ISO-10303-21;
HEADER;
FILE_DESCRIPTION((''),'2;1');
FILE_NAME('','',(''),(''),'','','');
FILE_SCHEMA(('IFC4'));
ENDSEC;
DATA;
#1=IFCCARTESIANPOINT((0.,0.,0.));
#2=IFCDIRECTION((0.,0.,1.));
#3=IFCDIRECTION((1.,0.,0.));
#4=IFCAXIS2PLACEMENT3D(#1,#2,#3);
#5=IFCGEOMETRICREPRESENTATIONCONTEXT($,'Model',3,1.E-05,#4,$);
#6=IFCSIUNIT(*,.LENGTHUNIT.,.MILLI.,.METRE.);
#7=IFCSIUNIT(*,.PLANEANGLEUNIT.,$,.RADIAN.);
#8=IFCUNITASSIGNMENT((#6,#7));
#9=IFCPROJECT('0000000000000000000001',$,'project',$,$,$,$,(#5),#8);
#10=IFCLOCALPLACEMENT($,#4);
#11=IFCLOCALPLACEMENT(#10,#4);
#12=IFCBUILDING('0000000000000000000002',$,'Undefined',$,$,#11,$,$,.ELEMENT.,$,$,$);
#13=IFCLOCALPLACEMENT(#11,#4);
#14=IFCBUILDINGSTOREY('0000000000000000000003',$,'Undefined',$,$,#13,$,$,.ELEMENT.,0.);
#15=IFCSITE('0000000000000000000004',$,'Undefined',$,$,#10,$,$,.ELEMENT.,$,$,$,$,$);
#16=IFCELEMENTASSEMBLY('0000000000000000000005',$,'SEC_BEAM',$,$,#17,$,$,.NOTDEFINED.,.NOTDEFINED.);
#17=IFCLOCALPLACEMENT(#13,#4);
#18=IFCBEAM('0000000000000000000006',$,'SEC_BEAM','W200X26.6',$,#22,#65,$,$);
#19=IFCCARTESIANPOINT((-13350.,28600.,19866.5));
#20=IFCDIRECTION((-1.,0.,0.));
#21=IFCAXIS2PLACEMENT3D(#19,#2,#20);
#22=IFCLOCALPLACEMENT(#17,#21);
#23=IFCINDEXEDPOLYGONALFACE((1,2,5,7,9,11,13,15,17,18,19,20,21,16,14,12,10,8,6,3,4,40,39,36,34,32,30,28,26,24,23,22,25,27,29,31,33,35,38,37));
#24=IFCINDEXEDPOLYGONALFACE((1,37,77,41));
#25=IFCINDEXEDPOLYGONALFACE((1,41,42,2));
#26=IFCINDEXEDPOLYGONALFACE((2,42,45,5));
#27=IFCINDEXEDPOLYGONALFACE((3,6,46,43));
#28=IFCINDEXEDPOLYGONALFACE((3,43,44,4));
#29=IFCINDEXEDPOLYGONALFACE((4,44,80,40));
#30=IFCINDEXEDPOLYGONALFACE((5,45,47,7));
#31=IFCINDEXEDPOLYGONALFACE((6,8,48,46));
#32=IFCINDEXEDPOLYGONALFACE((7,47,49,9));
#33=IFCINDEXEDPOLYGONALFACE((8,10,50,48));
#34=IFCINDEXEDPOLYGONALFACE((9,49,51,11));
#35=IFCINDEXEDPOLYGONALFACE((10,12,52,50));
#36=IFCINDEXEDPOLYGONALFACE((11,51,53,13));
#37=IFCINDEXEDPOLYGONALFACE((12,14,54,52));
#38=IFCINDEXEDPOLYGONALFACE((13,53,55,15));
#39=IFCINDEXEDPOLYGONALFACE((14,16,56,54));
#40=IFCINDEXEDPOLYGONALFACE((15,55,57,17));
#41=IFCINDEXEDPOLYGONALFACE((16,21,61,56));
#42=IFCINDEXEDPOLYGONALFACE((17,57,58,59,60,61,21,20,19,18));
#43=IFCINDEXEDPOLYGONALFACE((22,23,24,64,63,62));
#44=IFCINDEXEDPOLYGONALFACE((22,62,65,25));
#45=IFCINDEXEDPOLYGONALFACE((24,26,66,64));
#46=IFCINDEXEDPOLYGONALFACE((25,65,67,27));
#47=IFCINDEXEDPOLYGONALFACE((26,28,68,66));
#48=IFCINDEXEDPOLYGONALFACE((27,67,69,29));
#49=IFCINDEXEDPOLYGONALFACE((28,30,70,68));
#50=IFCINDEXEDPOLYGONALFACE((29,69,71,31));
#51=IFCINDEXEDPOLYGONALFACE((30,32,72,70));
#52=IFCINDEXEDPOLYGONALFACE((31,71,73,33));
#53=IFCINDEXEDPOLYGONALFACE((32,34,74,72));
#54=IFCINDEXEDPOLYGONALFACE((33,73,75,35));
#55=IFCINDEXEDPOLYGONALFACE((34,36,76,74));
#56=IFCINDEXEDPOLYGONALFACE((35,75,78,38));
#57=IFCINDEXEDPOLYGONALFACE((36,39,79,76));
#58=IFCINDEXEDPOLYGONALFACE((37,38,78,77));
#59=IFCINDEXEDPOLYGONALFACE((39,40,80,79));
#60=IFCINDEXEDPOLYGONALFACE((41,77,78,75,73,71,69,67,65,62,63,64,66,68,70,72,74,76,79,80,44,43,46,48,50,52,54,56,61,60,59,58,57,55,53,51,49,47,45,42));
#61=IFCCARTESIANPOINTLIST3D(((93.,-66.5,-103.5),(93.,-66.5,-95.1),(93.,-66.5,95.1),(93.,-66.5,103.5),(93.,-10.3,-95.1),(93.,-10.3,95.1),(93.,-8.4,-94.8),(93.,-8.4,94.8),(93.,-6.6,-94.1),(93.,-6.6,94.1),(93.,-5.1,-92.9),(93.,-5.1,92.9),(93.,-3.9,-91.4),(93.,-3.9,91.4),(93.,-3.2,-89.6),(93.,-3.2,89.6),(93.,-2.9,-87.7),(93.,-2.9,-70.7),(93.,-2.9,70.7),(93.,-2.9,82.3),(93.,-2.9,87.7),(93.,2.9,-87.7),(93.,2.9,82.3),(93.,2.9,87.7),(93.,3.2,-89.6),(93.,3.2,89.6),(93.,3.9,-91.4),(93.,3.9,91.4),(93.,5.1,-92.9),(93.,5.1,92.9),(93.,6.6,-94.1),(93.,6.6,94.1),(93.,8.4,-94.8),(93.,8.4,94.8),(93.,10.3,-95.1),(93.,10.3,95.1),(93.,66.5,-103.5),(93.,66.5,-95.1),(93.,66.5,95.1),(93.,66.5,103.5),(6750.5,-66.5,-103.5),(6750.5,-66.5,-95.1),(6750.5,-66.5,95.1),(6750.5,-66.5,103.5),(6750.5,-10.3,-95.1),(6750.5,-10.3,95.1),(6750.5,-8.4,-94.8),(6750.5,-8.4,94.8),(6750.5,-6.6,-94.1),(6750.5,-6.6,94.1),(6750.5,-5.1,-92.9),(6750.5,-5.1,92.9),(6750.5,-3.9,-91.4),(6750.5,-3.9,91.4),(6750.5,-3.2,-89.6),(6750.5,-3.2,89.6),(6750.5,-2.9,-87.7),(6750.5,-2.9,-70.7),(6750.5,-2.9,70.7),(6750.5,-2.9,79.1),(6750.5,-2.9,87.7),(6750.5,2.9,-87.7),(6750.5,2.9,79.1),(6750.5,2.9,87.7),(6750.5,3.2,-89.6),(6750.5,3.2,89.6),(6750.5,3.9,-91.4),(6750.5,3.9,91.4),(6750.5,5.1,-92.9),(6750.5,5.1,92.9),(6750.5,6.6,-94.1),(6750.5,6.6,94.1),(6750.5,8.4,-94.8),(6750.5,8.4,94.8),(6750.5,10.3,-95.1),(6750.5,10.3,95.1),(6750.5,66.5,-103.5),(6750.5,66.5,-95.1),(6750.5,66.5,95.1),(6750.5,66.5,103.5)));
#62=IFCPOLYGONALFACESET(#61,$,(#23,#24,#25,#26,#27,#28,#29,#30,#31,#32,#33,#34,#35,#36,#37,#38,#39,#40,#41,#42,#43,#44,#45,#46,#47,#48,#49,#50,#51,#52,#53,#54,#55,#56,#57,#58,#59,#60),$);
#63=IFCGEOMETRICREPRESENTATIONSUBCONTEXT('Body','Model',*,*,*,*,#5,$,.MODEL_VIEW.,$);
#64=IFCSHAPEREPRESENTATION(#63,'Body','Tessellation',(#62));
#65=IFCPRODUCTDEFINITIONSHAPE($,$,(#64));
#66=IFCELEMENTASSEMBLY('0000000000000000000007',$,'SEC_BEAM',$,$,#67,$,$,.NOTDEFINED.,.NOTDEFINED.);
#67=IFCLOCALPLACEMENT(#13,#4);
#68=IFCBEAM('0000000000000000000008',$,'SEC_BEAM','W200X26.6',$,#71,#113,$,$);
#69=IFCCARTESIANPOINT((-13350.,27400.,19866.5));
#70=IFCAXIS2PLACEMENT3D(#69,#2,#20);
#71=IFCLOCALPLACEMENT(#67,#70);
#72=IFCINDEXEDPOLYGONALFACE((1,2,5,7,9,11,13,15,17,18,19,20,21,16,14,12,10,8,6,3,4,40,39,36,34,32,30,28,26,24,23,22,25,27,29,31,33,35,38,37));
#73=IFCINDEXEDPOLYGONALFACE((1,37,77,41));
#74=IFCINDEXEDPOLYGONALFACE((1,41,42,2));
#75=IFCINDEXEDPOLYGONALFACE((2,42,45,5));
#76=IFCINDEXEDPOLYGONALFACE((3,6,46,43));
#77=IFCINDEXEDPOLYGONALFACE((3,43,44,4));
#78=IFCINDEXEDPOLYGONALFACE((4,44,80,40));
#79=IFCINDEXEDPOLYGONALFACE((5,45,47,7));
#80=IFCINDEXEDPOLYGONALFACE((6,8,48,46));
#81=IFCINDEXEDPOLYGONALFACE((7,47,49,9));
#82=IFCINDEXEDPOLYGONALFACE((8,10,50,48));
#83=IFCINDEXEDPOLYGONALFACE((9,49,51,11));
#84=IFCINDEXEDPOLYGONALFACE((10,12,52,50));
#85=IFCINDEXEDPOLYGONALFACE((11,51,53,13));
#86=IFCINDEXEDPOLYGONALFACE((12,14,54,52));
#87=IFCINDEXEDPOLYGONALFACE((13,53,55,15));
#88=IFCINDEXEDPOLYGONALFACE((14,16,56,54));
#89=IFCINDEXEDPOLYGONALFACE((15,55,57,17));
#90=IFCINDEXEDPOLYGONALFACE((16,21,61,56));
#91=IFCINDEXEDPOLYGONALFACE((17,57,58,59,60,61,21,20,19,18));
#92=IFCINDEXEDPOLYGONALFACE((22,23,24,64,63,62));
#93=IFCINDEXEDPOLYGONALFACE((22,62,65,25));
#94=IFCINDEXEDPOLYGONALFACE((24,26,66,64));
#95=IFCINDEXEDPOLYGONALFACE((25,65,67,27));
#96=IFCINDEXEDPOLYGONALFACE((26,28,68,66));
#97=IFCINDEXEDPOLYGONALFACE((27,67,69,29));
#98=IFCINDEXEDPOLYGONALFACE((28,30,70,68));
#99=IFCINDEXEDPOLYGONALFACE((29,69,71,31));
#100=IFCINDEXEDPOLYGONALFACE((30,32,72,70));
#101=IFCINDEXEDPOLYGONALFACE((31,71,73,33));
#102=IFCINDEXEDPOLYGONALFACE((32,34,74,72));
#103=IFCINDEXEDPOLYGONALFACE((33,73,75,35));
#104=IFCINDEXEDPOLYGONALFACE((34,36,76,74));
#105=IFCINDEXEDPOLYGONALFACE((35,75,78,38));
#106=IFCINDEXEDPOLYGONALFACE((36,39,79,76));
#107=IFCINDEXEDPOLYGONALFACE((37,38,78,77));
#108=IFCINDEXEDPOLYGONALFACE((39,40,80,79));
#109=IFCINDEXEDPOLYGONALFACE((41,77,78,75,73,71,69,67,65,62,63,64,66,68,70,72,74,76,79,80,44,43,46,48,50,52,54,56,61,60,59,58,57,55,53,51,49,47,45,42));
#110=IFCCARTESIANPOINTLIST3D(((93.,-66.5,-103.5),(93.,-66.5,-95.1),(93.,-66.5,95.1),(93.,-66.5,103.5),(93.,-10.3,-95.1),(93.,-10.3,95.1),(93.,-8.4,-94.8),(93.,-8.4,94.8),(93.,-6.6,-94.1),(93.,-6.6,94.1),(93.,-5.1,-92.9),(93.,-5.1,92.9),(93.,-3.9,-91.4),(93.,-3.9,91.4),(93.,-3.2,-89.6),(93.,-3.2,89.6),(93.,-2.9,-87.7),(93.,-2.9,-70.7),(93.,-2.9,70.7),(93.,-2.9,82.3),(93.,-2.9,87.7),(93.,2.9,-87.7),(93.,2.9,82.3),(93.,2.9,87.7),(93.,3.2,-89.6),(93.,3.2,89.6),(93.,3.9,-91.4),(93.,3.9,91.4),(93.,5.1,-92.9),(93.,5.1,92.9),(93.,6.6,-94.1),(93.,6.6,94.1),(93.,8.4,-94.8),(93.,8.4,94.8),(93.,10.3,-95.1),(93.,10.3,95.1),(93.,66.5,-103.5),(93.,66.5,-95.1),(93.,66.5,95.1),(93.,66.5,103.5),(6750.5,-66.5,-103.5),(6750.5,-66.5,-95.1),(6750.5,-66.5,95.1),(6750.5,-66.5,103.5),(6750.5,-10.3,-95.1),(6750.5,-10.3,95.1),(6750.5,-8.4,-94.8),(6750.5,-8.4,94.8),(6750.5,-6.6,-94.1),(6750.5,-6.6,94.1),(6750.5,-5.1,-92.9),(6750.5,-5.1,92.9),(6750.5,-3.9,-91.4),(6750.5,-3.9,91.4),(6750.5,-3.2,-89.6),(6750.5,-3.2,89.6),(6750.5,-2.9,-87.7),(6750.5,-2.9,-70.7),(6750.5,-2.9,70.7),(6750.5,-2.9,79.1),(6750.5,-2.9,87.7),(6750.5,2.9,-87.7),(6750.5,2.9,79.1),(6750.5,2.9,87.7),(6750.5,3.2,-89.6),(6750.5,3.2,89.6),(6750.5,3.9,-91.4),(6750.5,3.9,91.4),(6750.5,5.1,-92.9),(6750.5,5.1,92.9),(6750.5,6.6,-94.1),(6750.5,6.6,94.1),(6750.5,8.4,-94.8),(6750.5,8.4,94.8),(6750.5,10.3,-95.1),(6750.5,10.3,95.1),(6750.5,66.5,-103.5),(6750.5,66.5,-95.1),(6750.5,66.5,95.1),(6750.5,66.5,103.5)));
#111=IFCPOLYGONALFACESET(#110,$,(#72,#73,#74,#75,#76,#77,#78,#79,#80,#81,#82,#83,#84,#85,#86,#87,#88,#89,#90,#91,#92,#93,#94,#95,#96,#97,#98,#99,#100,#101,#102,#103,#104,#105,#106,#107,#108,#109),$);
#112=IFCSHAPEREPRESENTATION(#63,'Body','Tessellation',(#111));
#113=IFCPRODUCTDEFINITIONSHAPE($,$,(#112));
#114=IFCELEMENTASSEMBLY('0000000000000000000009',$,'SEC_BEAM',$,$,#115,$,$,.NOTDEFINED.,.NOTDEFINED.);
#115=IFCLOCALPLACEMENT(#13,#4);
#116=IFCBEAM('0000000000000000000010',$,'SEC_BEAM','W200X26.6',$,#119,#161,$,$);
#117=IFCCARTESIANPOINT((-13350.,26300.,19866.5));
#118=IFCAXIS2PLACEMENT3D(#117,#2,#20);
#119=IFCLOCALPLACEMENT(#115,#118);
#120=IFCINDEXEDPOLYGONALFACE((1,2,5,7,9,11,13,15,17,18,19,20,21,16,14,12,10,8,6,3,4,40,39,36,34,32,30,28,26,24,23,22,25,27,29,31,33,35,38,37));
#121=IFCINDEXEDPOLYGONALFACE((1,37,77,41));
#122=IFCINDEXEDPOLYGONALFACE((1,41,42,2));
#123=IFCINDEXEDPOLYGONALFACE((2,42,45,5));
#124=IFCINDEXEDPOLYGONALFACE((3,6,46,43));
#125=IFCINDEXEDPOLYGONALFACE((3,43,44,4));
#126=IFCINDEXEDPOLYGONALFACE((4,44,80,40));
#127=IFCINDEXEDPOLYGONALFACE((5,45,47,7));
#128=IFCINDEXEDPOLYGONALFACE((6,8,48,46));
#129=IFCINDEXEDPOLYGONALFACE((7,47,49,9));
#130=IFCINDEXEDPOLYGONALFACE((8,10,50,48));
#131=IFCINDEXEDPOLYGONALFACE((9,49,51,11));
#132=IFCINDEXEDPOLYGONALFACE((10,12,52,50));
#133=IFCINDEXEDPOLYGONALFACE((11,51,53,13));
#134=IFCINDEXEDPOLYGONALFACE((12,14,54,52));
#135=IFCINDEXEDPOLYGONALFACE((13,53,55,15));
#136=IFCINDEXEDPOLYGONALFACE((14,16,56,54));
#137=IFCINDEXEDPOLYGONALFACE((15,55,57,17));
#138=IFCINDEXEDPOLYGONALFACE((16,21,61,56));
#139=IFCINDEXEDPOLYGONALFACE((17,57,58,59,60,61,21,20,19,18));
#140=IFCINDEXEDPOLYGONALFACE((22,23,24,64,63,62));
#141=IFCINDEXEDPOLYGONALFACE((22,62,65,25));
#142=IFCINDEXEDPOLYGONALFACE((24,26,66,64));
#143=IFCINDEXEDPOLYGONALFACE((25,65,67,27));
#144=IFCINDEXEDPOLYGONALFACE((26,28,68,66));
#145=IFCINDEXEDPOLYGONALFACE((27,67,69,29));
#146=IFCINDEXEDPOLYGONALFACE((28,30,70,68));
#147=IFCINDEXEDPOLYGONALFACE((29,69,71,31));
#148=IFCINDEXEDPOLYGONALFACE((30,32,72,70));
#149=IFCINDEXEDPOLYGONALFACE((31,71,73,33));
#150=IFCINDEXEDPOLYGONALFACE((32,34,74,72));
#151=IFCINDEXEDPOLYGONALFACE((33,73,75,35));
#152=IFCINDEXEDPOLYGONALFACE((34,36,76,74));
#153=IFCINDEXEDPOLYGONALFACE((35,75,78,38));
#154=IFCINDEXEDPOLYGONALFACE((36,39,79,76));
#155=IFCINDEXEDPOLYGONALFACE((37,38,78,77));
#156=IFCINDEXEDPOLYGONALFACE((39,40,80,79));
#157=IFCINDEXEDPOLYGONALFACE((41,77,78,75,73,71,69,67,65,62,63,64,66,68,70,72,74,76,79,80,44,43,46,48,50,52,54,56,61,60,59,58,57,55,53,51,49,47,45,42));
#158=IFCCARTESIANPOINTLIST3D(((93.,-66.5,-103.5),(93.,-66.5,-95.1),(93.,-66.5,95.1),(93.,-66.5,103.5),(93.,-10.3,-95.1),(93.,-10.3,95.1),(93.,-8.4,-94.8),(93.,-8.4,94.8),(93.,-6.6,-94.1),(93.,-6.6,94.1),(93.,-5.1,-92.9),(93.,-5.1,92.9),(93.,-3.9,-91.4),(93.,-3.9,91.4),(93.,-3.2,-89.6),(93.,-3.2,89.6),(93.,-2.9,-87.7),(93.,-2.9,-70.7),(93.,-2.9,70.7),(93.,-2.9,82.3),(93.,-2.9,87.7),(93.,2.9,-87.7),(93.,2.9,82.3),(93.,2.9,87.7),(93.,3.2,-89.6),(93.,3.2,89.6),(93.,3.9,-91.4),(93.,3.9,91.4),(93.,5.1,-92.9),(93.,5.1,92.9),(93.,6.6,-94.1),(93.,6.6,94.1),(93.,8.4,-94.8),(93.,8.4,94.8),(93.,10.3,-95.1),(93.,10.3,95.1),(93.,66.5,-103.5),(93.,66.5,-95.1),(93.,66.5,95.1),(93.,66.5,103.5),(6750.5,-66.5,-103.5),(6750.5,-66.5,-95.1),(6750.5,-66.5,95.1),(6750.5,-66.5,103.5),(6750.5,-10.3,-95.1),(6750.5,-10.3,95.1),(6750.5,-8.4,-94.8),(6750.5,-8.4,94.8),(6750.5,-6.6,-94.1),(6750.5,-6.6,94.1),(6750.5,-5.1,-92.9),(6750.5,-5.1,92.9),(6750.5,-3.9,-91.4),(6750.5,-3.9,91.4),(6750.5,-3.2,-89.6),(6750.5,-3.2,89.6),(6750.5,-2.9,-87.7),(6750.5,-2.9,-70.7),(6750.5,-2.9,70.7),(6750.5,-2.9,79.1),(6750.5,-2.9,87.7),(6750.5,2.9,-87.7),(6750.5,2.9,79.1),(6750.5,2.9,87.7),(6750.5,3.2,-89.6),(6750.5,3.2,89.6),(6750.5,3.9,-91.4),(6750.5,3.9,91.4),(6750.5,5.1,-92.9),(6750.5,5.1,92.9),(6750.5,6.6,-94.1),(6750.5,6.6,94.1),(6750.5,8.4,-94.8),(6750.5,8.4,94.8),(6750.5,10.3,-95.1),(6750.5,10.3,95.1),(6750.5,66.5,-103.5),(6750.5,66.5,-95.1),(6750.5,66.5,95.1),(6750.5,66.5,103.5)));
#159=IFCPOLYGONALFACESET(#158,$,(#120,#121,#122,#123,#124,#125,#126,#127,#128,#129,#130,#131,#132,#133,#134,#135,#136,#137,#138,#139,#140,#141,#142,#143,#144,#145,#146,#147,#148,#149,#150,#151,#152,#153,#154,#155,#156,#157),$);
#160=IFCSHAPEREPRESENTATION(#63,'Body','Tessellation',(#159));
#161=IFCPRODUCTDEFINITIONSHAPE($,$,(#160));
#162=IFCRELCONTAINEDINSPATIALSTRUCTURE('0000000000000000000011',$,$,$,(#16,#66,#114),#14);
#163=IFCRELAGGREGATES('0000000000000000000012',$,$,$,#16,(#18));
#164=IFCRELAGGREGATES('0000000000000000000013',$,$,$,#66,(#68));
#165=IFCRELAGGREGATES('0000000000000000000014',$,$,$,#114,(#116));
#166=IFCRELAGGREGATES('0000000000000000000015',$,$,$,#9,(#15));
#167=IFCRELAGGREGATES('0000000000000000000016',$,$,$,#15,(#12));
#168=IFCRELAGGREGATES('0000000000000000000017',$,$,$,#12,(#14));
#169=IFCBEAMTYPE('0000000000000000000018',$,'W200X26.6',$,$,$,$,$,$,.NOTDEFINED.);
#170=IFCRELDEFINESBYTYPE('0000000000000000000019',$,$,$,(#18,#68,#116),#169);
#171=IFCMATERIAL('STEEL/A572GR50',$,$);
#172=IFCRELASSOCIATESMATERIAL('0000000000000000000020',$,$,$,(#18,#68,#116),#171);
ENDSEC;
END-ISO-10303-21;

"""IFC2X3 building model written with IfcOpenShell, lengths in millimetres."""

from ifc_helpers import new_model, si_unit, frame, origin_with_axes, origin_2d_with_axis, place, context, subcontext, project, spatial, polyline, rectangle, i_section, outline, extrude, boolean, halfspace, material, type_object, element, aggregate, save


model = new_model("IFC2X3")

# Units and contexts
model_context = context("Model", 3, precision=1e-05, world=origin_with_axes())
body_context = subcontext(model_context, "Body", "Model", "MODEL_VIEW")
ifc_project = project(units=[si_unit("LENGTHUNIT", "METRE", prefix="MILLI"), si_unit("PLANEANGLEUNIT", "RADIAN")], contexts=[model_context])

# Site, building, storey
site_placement = place(None, origin_with_axes())
site = spatial("IfcSite", under=ifc_project, at=site_placement, Name="Undefined", CompositionType="ELEMENT")
building_placement = place(site_placement, origin_with_axes())
building = spatial("IfcBuilding", under=site, at=building_placement, Name="Undefined", CompositionType="ELEMENT")
storey_placement = place(building_placement, origin_with_axes())
storey = spatial("IfcBuildingStorey", under=building, at=storey_placement, Name="Undefined", CompositionType="ELEMENT", Elevation=0.0)

# Shared definitions
ifc_material_1 = material(Name="STEEL/A572GR50")

# Element assemblies, beams
assembly_1_placement = place(storey_placement, origin_with_axes())
assembly_1 = element("IfcElementAssembly", 1, at=assembly_1_placement, inside=storey, Name="SEC_BEAM", AssemblyPlace="NOTDEFINED", PredefinedType="NOTDEFINED")
beam_type_1 = type_object("IfcBeamType", Name="W200X26.6", PredefinedType="NOTDEFINED")
beam_1_placement = place(assembly_1_placement, frame((-13350.0, 28600.0, 19866.5), z_axis=(0.0, 0.0, 1.0), x_axis=(-1.0, 0.0, 0.0)))
beam_1 = element("IfcBeam", 2, at=beam_1_placement, type_object=beam_type_1, material=ifc_material_1, Name="SEC_BEAM", Description="W200X26.6", context=body_context, shape_type="CSG", body=[
    boolean("DIFFERENCE", boolean("DIFFERENCE", boolean("DIFFERENCE", boolean("DIFFERENCE", boolean("DIFFERENCE", boolean("DIFFERENCE", extrude(i_section(OverallWidth=133.0, OverallDepth=207.0, WebThickness=5.8, FlangeThickness=8.4, FilletRadius=7.4, at=origin_2d_with_axis()), frame((6850.0, 0.0, 0.0), z_axis=(-1.0, 0.0, 0.0), x_axis=(0.0, -1.0, 0.0)), (0.0, 0.0, 1.0), 6850.0), extrude(outline(polyline([(0.0, 0.0), (10.0, 0.0), (10.0, 31.2), (0.0, 31.2), (0.0, 0.0)])), frame((83.0, 76.5, 82.3), z_axis=(0.0, -1.0, 0.0), x_axis=(1.0, 0.0, 0.0)), (0.0, 0.0, 1.0), 153.0)), extrude(rectangle(XDim=159.7, YDim=159.7, at=origin_2d_with_axis()), frame((83.1, -82.8, 70.7), z_axis=(0.0, 0.0, -1.0), x_axis=(1.0, 0.0, 0.0)), (0.0, 0.0, 1.0), 141.5)), extrude(outline(polyline([(0.0, 0.0), (34.4, 0.0), (34.4, 10.0), (0.0, 10.0), (0.0, 0.0)])), frame((6750.5, -76.5, 79.1), z_axis=(0.0, 1.0, 0.0), x_axis=(0.0, 0.0, 1.0)), (0.0, 0.0, 1.0), 153.0)), extrude(rectangle(XDim=165.1, YDim=165.1, at=origin_2d_with_axis()), frame((6763.0, -85.5, 70.7), z_axis=(0.0, 0.0, -1.0), x_axis=(-1.0, 0.0, 0.0)), (0.0, 0.0, 1.0), 141.5)), halfspace(frame((6750.5, 0.0, 203.5), z_axis=(1.0, 0.0, 0.0), x_axis=(0.0, 1.0, 0.0)), False)), halfspace(frame((93.0, 0.0, 203.5), z_axis=(-1.0, 0.0, 0.0), x_axis=(0.0, -1.0, 0.0)), False)),
])
assembly_2_placement = place(storey_placement, origin_with_axes())
assembly_2 = element("IfcElementAssembly", 3, at=assembly_2_placement, inside=storey, Name="SEC_BEAM", AssemblyPlace="NOTDEFINED", PredefinedType="NOTDEFINED")
beam_2_placement = place(assembly_2_placement, frame((-13350.0, 27400.0, 19866.5), z_axis=(0.0, 0.0, 1.0), x_axis=(-1.0, 0.0, 0.0)))
beam_2 = element("IfcBeam", 4, at=beam_2_placement, type_object=beam_type_1, material=ifc_material_1, Name="SEC_BEAM", Description="W200X26.6", context=body_context, shape_type="CSG", body=[
    boolean("DIFFERENCE", boolean("DIFFERENCE", boolean("DIFFERENCE", boolean("DIFFERENCE", boolean("DIFFERENCE", boolean("DIFFERENCE", extrude(i_section(OverallWidth=133.0, OverallDepth=207.0, WebThickness=5.8, FlangeThickness=8.4, FilletRadius=7.4, at=origin_2d_with_axis()), frame((6850.0, 0.0, 0.0), z_axis=(-1.0, 0.0, 0.0), x_axis=(0.0, -1.0, 0.0)), (0.0, 0.0, 1.0), 6850.0), extrude(outline(polyline([(0.0, 0.0), (10.0, 0.0), (10.0, 31.2), (0.0, 31.2), (0.0, 0.0)])), frame((83.0, 76.5, 82.3), z_axis=(0.0, -1.0, 0.0), x_axis=(1.0, 0.0, 0.0)), (0.0, 0.0, 1.0), 153.0)), extrude(rectangle(XDim=159.7, YDim=159.7, at=origin_2d_with_axis()), frame((83.1, -82.8, 70.7), z_axis=(0.0, 0.0, -1.0), x_axis=(1.0, 0.0, 0.0)), (0.0, 0.0, 1.0), 141.5)), extrude(outline(polyline([(0.0, 0.0), (34.4, 0.0), (34.4, 10.0), (0.0, 10.0), (0.0, 0.0)])), frame((6750.5, -76.5, 79.1), z_axis=(0.0, 1.0, 0.0), x_axis=(0.0, 0.0, 1.0)), (0.0, 0.0, 1.0), 153.0)), extrude(rectangle(XDim=165.1, YDim=165.1, at=origin_2d_with_axis()), frame((6763.0, -85.5, 70.7), z_axis=(0.0, 0.0, -1.0), x_axis=(-1.0, 0.0, 0.0)), (0.0, 0.0, 1.0), 141.5)), halfspace(frame((6750.5, 0.0, 203.5), z_axis=(1.0, 0.0, 0.0), x_axis=(0.0, 1.0, 0.0)), False)), halfspace(frame((93.0, 0.0, 203.5), z_axis=(-1.0, 0.0, 0.0), x_axis=(0.0, -1.0, 0.0)), False)),
])
assembly_3_placement = place(storey_placement, origin_with_axes())
assembly_3 = element("IfcElementAssembly", 5, at=assembly_3_placement, inside=storey, Name="SEC_BEAM", AssemblyPlace="NOTDEFINED", PredefinedType="NOTDEFINED")
beam_3_placement = place(assembly_3_placement, frame((-13350.0, 26300.0, 19866.5), z_axis=(0.0, 0.0, 1.0), x_axis=(-1.0, 0.0, 0.0)))
beam_3 = element("IfcBeam", 6, at=beam_3_placement, type_object=beam_type_1, material=ifc_material_1, Name="SEC_BEAM", Description="W200X26.6", context=body_context, shape_type="CSG", body=[
    boolean("DIFFERENCE", boolean("DIFFERENCE", boolean("DIFFERENCE", boolean("DIFFERENCE", boolean("DIFFERENCE", boolean("DIFFERENCE", extrude(i_section(OverallWidth=133.0, OverallDepth=207.0, WebThickness=5.8, FlangeThickness=8.4, FilletRadius=7.4, at=origin_2d_with_axis()), frame((6850.0, 0.0, 0.0), z_axis=(-1.0, 0.0, 0.0), x_axis=(0.0, -1.0, 0.0)), (0.0, 0.0, 1.0), 6850.0), extrude(outline(polyline([(0.0, 0.0), (10.0, 0.0), (10.0, 31.2), (0.0, 31.2), (0.0, 0.0)])), frame((83.0, 76.5, 82.3), z_axis=(0.0, -1.0, 0.0), x_axis=(1.0, 0.0, 0.0)), (0.0, 0.0, 1.0), 153.0)), extrude(rectangle(XDim=159.7, YDim=159.7, at=origin_2d_with_axis()), frame((83.1, -82.8, 70.7), z_axis=(0.0, 0.0, -1.0), x_axis=(1.0, 0.0, 0.0)), (0.0, 0.0, 1.0), 141.5)), extrude(outline(polyline([(0.0, 0.0), (34.4, 0.0), (34.4, 10.0), (0.0, 10.0), (0.0, 0.0)])), frame((6750.5, -76.5, 79.1), z_axis=(0.0, 1.0, 0.0), x_axis=(0.0, 0.0, 1.0)), (0.0, 0.0, 1.0), 153.0)), extrude(rectangle(XDim=165.1, YDim=165.1, at=origin_2d_with_axis()), frame((6763.0, -85.5, 70.7), z_axis=(0.0, 0.0, -1.0), x_axis=(-1.0, 0.0, 0.0)), (0.0, 0.0, 1.0), 141.5)), halfspace(frame((6750.5, 0.0, 203.5), z_axis=(1.0, 0.0, 0.0), x_axis=(0.0, 1.0, 0.0)), False)), halfspace(frame((93.0, 0.0, 203.5), z_axis=(-1.0, 0.0, 0.0), x_axis=(0.0, -1.0, 0.0)), False)),
])

aggregate(assembly_1, [beam_1])
aggregate(assembly_2, [beam_2])
aggregate(assembly_3, [beam_3])

save(model, "model.ifc")
